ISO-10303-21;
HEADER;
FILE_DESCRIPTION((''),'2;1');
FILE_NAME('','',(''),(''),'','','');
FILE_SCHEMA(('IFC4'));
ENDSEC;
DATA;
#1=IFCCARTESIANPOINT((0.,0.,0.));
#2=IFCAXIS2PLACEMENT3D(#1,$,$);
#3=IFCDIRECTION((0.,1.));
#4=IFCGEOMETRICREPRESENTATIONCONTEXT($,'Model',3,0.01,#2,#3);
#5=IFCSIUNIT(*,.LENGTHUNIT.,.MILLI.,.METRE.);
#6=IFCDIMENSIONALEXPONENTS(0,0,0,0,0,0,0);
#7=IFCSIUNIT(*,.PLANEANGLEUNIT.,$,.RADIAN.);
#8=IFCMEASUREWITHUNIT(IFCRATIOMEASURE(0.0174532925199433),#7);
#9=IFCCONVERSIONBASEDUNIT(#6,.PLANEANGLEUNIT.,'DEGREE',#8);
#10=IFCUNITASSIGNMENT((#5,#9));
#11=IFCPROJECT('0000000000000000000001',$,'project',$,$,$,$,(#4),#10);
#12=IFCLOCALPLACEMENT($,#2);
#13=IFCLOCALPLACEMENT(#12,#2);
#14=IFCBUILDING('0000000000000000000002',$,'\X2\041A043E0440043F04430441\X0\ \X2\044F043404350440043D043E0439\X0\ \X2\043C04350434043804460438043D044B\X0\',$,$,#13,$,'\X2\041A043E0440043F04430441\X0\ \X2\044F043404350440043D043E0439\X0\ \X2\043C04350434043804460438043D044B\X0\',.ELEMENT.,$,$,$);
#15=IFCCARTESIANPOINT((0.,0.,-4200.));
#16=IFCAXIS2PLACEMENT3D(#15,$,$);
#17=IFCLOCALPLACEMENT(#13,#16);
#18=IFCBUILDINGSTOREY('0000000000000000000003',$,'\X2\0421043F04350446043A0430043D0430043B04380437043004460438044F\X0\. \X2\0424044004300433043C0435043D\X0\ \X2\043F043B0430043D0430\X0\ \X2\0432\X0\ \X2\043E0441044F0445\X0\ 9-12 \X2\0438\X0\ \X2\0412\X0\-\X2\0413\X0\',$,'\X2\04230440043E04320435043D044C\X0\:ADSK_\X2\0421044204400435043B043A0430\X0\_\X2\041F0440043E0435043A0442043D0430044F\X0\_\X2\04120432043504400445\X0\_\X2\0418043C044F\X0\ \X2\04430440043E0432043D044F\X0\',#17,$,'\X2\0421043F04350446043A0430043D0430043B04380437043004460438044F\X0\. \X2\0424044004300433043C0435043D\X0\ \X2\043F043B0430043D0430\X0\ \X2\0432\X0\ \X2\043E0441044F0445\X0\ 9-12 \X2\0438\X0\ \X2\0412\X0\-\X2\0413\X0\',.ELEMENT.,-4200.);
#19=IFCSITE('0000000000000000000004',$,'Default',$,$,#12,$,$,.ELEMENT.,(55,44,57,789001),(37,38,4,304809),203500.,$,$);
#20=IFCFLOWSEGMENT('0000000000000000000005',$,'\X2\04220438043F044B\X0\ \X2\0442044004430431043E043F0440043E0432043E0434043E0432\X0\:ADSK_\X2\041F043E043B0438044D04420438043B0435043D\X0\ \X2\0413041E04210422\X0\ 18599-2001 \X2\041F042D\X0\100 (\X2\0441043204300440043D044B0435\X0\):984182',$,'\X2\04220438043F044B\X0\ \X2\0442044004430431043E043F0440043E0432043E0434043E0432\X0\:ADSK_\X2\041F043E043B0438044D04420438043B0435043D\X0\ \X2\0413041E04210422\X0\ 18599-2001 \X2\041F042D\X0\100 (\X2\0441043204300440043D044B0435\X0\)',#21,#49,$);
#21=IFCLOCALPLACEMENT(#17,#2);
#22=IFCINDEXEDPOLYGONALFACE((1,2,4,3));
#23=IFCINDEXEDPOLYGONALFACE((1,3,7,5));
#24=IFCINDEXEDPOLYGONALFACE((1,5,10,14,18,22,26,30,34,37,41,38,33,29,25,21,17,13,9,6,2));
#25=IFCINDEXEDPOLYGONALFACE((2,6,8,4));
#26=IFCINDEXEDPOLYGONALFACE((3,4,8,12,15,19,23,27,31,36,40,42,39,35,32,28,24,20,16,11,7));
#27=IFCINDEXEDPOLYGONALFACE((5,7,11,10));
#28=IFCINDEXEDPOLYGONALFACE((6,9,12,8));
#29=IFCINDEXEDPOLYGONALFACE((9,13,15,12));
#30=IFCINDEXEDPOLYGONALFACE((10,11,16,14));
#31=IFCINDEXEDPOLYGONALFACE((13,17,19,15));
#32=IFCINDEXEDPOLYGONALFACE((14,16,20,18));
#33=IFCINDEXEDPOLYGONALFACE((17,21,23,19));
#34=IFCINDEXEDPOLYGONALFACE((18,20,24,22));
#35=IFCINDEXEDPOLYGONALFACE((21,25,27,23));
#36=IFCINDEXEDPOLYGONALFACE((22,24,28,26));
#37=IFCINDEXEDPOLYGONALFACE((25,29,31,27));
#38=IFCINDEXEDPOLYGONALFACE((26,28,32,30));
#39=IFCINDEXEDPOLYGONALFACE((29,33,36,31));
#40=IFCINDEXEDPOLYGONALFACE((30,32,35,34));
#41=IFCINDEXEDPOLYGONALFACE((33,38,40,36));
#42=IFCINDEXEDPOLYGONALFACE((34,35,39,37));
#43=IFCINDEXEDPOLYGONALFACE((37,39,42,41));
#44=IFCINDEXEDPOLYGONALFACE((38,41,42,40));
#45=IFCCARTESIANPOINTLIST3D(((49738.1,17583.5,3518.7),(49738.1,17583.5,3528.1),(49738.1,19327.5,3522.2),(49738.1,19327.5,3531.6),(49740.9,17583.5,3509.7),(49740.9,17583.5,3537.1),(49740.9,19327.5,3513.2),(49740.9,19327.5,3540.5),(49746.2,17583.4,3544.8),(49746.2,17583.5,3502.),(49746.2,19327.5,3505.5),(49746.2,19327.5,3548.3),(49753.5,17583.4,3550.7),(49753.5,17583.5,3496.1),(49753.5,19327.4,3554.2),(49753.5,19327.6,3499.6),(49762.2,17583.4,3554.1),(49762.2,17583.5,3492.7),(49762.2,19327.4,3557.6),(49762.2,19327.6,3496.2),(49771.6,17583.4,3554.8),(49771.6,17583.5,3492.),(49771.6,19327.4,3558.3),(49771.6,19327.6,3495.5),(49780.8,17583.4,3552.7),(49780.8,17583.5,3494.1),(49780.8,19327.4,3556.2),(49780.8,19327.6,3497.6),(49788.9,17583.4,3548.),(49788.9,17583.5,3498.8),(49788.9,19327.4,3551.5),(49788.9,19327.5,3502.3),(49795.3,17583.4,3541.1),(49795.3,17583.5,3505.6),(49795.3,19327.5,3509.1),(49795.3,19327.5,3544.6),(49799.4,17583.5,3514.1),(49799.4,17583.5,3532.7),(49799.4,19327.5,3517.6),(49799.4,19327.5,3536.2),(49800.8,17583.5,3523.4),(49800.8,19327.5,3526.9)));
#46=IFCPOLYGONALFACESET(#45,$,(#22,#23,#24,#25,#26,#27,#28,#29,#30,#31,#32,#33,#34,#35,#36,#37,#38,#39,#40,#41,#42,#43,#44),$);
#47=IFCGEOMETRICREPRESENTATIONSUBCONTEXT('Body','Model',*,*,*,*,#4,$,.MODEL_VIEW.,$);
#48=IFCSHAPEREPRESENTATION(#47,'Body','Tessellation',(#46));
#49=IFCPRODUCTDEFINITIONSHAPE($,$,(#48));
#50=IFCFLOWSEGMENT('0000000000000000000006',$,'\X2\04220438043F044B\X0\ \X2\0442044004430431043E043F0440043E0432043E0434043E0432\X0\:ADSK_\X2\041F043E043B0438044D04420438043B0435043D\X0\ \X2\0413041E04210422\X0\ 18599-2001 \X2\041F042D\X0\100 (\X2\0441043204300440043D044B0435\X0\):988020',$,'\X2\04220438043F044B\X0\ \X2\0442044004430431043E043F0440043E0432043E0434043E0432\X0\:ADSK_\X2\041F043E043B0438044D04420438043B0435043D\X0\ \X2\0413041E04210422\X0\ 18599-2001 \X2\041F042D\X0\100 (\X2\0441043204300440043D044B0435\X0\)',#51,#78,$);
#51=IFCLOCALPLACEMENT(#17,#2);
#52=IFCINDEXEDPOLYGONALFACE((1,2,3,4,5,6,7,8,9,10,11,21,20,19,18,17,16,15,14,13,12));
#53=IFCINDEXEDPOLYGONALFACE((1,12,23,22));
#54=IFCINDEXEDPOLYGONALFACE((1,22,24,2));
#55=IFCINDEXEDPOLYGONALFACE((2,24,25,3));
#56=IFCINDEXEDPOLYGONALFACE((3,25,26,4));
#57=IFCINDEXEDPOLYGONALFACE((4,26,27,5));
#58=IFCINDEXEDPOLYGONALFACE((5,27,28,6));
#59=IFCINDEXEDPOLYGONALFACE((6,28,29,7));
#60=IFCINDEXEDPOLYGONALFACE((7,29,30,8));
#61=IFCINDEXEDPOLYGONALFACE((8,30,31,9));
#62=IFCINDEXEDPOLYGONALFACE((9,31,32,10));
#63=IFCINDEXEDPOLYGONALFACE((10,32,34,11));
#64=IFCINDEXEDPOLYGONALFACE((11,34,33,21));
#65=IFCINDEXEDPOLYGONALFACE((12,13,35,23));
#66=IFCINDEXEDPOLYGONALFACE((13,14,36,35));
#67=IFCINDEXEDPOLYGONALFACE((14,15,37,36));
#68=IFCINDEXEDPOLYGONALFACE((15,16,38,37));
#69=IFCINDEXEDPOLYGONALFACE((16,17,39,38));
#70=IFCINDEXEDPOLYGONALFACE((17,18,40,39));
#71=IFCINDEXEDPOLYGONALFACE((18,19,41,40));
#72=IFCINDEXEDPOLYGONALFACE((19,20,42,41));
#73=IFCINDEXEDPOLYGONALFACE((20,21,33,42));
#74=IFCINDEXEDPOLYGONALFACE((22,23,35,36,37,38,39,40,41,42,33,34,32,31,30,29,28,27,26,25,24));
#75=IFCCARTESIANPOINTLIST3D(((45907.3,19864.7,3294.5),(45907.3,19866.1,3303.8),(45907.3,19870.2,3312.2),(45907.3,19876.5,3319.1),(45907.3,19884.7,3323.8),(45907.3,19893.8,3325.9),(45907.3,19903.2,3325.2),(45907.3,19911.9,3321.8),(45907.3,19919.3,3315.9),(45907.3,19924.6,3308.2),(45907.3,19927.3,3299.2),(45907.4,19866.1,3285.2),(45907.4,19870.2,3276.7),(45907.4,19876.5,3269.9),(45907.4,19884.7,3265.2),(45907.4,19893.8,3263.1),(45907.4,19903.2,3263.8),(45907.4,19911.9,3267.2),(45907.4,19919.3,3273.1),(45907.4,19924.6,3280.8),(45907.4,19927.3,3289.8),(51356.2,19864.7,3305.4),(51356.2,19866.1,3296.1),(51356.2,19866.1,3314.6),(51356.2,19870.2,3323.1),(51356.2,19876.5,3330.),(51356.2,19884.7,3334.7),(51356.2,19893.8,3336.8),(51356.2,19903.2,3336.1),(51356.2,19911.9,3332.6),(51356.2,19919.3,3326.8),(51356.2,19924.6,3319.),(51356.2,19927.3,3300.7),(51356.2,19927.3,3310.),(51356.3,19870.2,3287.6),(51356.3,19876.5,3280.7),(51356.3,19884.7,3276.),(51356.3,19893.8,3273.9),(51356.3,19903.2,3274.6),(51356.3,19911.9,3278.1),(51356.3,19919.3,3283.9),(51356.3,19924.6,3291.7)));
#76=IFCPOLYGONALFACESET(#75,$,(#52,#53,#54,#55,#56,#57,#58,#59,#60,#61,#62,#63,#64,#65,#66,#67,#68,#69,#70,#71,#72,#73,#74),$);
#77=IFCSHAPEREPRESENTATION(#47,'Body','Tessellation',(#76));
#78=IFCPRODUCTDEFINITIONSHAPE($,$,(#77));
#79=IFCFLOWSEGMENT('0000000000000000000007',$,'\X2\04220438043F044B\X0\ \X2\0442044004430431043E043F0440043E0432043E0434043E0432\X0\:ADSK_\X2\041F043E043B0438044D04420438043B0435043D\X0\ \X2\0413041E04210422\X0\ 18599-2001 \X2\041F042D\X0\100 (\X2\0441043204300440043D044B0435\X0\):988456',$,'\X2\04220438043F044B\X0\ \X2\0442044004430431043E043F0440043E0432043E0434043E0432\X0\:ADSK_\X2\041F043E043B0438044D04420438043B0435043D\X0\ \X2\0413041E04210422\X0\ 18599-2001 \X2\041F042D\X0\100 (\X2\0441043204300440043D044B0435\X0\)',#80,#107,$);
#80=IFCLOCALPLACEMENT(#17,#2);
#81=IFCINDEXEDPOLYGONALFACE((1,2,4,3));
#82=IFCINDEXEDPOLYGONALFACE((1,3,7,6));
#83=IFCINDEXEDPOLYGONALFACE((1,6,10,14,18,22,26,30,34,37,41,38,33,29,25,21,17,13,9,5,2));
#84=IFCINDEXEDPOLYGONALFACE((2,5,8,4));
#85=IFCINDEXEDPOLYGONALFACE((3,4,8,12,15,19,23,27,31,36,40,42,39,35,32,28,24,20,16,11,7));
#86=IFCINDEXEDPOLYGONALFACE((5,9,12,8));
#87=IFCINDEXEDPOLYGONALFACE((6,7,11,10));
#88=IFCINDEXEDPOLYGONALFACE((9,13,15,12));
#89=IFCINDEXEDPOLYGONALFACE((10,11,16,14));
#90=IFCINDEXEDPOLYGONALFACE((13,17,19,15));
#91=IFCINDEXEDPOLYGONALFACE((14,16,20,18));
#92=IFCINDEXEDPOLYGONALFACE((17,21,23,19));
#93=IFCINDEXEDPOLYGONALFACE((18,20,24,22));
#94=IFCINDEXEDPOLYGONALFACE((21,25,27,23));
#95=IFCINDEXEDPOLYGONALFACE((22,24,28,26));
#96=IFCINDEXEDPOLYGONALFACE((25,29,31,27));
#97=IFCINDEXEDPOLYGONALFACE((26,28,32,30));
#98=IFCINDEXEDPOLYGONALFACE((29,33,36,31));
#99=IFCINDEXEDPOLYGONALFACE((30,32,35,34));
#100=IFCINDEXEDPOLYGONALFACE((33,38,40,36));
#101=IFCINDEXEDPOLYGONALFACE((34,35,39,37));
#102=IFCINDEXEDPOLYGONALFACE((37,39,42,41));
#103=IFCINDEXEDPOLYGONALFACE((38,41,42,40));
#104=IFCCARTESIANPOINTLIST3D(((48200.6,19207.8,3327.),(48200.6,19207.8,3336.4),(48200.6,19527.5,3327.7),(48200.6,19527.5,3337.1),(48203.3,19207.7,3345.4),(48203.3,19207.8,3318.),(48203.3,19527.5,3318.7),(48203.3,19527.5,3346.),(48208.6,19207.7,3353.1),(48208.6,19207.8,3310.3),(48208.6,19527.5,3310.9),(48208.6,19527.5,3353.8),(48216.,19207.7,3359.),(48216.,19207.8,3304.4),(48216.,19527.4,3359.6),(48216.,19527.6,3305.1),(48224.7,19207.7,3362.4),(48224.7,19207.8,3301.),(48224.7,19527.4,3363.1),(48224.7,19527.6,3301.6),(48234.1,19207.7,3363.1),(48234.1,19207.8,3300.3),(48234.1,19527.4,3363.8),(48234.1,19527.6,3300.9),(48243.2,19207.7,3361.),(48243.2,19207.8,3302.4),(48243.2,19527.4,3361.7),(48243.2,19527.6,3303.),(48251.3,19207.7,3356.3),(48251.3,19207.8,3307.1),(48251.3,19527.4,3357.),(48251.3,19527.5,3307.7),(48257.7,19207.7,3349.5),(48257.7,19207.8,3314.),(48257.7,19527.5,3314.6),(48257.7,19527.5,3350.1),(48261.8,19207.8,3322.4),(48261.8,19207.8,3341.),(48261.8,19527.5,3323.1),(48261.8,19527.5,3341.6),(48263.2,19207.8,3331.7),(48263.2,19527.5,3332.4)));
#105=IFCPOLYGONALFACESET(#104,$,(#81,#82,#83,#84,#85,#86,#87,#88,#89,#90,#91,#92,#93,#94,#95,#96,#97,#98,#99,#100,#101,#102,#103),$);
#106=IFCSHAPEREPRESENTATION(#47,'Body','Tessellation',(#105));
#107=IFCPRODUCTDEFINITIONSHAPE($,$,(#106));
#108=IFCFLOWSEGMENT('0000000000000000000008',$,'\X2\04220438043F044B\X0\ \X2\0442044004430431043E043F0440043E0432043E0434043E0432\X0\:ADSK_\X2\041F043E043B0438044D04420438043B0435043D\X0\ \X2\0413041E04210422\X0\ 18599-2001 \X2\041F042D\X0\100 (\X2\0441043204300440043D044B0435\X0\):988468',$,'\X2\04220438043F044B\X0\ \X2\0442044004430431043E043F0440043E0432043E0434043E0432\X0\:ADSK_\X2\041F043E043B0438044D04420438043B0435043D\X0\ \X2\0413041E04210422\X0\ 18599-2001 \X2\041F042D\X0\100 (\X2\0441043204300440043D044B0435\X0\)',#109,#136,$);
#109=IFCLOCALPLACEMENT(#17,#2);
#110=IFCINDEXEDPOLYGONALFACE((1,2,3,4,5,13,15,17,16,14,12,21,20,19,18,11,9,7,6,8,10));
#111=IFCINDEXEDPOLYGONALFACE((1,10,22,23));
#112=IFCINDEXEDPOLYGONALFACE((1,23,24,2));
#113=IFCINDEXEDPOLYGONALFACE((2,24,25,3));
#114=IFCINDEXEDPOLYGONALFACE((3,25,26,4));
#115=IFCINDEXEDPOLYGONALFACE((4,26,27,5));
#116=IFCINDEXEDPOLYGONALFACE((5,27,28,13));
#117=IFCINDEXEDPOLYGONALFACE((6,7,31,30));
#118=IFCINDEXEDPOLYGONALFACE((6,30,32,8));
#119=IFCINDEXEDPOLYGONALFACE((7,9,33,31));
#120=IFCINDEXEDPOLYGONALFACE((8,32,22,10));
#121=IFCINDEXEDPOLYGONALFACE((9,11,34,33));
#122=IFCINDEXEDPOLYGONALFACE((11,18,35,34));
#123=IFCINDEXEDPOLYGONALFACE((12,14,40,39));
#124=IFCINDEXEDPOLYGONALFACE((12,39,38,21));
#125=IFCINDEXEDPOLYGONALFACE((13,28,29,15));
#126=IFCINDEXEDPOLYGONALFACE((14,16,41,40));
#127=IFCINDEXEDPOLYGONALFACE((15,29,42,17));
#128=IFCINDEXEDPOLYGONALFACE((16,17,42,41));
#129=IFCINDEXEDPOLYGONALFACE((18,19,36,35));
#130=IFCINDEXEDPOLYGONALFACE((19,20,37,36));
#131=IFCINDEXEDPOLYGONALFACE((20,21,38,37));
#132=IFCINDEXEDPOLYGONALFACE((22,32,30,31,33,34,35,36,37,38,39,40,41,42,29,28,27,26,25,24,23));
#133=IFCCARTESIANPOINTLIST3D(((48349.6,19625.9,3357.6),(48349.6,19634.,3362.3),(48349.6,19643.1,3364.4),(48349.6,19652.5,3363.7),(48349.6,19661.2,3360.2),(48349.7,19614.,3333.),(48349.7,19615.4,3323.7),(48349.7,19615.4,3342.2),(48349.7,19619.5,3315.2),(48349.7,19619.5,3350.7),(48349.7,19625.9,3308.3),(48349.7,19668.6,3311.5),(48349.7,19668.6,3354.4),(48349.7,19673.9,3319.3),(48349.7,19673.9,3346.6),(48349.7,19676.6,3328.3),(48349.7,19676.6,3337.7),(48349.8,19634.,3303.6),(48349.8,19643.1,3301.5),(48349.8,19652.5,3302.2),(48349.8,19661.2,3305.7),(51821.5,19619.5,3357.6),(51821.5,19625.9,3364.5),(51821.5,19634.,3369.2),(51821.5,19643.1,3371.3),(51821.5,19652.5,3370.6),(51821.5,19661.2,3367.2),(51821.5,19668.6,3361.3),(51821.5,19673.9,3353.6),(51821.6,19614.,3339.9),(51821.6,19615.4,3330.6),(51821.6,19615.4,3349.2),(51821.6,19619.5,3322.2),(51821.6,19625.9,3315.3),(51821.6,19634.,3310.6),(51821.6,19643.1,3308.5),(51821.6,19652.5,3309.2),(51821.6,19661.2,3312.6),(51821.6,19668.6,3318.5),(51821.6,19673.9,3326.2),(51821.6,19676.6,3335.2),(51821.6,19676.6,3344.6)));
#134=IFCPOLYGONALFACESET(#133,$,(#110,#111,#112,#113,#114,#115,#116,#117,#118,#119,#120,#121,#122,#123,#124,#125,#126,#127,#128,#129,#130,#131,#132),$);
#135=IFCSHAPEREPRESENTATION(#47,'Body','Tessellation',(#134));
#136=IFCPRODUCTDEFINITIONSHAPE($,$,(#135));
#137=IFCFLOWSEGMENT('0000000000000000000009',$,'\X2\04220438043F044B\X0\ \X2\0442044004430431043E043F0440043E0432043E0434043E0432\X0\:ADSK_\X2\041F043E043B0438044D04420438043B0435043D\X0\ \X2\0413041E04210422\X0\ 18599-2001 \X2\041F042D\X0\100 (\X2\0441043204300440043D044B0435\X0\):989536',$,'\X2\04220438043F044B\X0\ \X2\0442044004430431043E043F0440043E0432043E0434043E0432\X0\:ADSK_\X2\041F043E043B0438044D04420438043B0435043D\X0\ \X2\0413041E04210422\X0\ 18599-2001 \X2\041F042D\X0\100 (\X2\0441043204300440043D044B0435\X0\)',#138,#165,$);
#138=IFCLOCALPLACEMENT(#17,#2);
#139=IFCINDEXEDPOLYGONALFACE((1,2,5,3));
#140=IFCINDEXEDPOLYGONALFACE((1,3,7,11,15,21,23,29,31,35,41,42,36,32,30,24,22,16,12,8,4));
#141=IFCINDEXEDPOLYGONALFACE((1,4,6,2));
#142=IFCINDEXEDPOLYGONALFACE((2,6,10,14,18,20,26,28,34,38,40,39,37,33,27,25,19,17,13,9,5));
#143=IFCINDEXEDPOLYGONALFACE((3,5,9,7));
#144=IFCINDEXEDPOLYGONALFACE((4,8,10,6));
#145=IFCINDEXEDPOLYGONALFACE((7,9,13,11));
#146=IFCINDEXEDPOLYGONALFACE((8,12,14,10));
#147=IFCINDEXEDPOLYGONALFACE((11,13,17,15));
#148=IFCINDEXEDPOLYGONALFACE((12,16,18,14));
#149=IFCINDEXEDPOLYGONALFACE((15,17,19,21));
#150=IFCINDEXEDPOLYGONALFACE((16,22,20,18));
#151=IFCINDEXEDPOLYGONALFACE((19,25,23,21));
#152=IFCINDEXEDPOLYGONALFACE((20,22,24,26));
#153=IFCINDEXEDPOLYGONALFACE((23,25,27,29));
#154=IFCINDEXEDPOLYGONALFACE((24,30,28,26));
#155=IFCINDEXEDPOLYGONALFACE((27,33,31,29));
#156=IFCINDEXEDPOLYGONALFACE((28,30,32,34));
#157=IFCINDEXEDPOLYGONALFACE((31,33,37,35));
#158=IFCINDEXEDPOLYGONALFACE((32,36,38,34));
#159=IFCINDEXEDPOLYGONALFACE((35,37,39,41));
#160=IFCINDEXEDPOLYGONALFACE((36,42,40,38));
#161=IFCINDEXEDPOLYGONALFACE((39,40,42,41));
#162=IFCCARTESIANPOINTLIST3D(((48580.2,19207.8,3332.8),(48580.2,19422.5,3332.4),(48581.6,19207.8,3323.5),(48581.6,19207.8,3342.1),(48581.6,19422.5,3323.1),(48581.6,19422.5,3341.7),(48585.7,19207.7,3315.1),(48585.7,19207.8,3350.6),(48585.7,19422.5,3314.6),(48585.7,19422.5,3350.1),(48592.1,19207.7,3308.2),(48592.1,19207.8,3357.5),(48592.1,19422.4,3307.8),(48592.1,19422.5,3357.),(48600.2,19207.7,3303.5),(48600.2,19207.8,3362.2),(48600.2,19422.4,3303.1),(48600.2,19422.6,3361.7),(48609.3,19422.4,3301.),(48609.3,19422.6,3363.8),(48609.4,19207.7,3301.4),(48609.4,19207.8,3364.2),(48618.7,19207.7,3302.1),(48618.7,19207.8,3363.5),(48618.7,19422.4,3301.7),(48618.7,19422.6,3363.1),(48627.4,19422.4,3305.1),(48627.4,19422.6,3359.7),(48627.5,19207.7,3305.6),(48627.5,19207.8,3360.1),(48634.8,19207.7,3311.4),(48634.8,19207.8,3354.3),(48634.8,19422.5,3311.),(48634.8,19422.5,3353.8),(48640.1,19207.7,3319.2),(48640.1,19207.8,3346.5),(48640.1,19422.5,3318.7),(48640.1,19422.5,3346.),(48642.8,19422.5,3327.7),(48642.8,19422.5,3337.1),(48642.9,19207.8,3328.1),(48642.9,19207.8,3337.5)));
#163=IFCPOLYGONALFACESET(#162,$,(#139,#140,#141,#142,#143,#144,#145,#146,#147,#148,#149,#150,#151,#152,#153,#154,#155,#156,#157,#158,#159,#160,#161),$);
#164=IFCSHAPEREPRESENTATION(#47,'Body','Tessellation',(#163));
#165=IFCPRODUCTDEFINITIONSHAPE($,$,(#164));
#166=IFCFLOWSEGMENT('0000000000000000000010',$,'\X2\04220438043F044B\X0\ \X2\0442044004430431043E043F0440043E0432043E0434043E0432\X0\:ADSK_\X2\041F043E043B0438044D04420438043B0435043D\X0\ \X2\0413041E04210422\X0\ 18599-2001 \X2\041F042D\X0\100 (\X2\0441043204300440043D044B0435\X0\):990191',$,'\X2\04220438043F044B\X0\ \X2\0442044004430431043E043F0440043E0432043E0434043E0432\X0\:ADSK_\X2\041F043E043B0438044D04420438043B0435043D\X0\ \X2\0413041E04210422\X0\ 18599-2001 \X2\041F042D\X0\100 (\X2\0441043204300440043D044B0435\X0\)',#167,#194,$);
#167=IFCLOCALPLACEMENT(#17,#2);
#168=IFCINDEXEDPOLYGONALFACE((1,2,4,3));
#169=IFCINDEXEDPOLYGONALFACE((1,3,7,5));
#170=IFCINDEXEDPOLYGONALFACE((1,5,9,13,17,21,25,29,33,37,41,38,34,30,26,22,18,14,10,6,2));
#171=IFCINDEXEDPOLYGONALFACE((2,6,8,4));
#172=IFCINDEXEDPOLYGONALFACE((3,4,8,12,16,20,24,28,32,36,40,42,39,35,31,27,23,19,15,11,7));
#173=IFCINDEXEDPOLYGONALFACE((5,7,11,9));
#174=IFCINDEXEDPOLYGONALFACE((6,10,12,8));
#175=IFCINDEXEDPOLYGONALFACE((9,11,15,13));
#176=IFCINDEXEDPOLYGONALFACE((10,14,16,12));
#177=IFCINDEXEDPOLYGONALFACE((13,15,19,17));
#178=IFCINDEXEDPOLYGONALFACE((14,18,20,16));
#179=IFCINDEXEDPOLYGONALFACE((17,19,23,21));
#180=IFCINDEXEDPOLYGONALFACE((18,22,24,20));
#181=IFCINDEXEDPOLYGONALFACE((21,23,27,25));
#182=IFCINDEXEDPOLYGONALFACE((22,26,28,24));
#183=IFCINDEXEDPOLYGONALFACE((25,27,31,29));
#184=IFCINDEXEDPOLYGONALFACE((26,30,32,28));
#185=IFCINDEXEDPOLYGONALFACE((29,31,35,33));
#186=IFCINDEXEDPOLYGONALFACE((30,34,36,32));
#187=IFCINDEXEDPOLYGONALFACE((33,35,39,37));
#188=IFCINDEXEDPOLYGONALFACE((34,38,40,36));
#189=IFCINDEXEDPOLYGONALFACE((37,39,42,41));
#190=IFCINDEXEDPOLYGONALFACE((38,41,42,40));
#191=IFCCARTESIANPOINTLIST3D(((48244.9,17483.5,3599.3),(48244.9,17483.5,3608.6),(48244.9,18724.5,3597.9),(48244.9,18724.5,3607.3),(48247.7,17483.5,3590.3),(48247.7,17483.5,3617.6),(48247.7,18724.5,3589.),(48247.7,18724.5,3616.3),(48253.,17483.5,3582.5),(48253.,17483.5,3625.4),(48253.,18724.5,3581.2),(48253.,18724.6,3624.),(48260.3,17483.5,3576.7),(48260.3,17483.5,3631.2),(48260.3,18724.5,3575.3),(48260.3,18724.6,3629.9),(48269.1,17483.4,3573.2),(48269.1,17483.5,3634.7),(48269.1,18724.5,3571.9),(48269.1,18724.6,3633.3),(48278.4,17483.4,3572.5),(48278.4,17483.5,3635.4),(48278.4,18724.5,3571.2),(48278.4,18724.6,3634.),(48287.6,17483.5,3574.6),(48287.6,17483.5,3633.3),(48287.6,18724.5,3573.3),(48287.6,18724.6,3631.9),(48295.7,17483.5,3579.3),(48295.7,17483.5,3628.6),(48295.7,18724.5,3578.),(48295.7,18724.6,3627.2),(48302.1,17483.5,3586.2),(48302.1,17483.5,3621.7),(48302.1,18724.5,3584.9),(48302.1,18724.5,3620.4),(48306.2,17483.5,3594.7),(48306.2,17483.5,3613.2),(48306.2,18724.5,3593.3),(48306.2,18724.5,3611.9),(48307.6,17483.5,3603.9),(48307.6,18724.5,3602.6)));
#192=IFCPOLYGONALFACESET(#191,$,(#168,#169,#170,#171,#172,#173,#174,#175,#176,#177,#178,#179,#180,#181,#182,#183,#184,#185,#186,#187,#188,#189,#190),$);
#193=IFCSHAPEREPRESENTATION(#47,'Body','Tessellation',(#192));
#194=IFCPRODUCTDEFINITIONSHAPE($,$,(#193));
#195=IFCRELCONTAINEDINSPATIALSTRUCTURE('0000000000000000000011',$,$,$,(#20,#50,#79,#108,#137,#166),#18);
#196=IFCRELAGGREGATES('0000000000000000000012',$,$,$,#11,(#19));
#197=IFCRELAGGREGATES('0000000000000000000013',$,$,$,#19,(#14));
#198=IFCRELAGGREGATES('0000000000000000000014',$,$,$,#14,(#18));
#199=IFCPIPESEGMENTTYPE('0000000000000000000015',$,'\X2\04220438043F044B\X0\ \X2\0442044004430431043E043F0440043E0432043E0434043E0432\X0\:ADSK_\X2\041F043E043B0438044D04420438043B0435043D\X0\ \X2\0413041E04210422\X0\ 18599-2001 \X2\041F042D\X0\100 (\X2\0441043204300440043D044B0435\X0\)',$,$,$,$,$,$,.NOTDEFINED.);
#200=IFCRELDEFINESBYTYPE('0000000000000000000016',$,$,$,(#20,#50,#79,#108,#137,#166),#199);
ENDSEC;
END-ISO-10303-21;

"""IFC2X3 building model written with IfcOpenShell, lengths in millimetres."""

from ifc_helpers import new_model, entity, si_unit, converted_unit, direction, frame, frame_2d, origin, origin_2d_with_axis, place, context, subcontext, project, spatial, circle, extrude, type_object, element, save


model = new_model("IFC2X3")

# Units and contexts
model_context = context("Model", 3, precision=0.01, world=origin(), true_north=direction((0.0, 1.0)))
body_context = subcontext(model_context, "Body", "Model", "MODEL_VIEW")
ifc_project = project(units=[si_unit("LENGTHUNIT", "METRE", prefix="MILLI"), converted_unit("PLANEANGLEUNIT", "DEGREE", entity("IfcRatioMeasure", 0.0174532925199433), si_unit("PLANEANGLEUNIT", "RADIAN"), dimensions=[0, 0, 0, 0, 0, 0, 0])], contexts=[model_context])

# Site, building, storey
site_placement = place(None, frame((0.0, 0.0, 0.0)))
site = spatial("IfcSite", under=ifc_project, at=site_placement, Name="Default", CompositionType="ELEMENT", RefLatitude=(55, 44, 57, 789001), RefLongitude=(37, 38, 4, 304809), RefElevation=203500.0)
building_placement = place(site_placement, origin())
building = spatial("IfcBuilding", under=site, at=building_placement, Name="Корпус ядерной медицины", LongName="Корпус ядерной медицины", CompositionType="ELEMENT")
storey_placement = place(building_placement, frame((0.0, 0.0, -4200.0)))
storey = spatial("IfcBuildingStorey", under=building, at=storey_placement, Name="Спецканализация. Фрагмен плана в осях 9-12 и В-Г", ObjectType="Уровень:ADSK_Стрелка_Проектная_Вверх_Имя уровня", LongName="Спецканализация. Фрагмен плана в осях 9-12 и В-Г", CompositionType="ELEMENT", Elevation=-4200.0)

# Flow segments
pipe_segment_type = type_object("IfcPipeSegmentType", Name="Типы трубопроводов:ADSK_Полиэтилен ГОСТ 18599-2001 ПЭ100 (сварные)", PredefinedType="NOTDEFINED")
flow_segment_1_placement = place(storey_placement, frame((49736.2, 17583.4, 3490.3)))
element("IfcFlowSegment", 1, at=flow_segment_1_placement, inside=storey, type_object=pipe_segment_type, Name="Типы трубопроводов:ADSK_Полиэтилен ГОСТ 18599-2001 ПЭ100 (сварные):984182", ObjectType="Типы трубопроводов:ADSK_Полиэтилен ГОСТ 18599-2001 ПЭ100 (сварные)", context=body_context, shape_type="SweptSolid", body=[
    extrude(circle(Radius=31.5, at=origin_2d_with_axis()), frame((33.1, 0.1, 33.1), z_axis=(0.0, 0.999998, 0.002), x_axis=(1.0, 0.0, 0.0)), (0.0, 0.0, 1.0), 1744.0),
])
flow_segment_2_placement = place(storey_placement, frame((45907.3, 19863.1, 3261.4)))
element("IfcFlowSegment", 2, at=flow_segment_2_placement, inside=storey, type_object=pipe_segment_type, Name="Типы трубопроводов:ADSK_Полиэтилен ГОСТ 18599-2001 ПЭ100 (сварные):988020", ObjectType="Типы трубопроводов:ADSK_Полиэтилен ГОСТ 18599-2001 ПЭ100 (сварные)", context=body_context, shape_type="SweptSolid", body=[
    extrude(circle(Radius=31.5, at=origin_2d_with_axis()), frame((0.1, 33.1, 33.1), z_axis=(0.999998, 0.0, 0.001995), x_axis=(0.0, -1.0, 0.0)), (0.0, 0.0, 1.0), 5448.9),
])
flow_segment_3_placement = place(storey_placement, frame((48198.6, 19207.7, 3298.6)))
element("IfcFlowSegment", 3, at=flow_segment_3_placement, inside=storey, type_object=pipe_segment_type, Name="Типы трубопроводов:ADSK_Полиэтилен ГОСТ 18599-2001 ПЭ100 (сварные):988456", ObjectType="Типы трубопроводов:ADSK_Полиэтилен ГОСТ 18599-2001 ПЭ100 (сварные)", context=body_context, shape_type="SweptSolid", body=[
    extrude(circle(Radius=31.5, at=origin_2d_with_axis()), frame((33.1, 0.1, 33.1), z_axis=(-0.000006, 0.999998, 0.002035), x_axis=(1.0, 0.000006, 0.0)), (0.0, 0.0, 1.0), 319.7),
])
flow_segment_4_placement = place(storey_placement, frame((48349.6, 19612.4, 3299.9)))
element("IfcFlowSegment", 4, at=flow_segment_4_placement, inside=storey, type_object=pipe_segment_type, Name="Типы трубопроводов:ADSK_Полиэтилен ГОСТ 18599-2001 ПЭ100 (сварные):988468", ObjectType="Типы трубопроводов:ADSK_Полиэтилен ГОСТ 18599-2001 ПЭ100 (сварные)", context=body_context, shape_type="SweptSolid", body=[
    extrude(circle(Radius=31.5, at=frame_2d((0.0, 0.0), x_axis=(1.0, 0.0))), frame((0.1, 33.1, 33.1), z_axis=(0.999998, 0.0, 0.002), x_axis=(0.0, -1.0, 0.0)), (0.0, 0.0, 1.0), 3471.9),
])
flow_segment_5_placement = place(storey_placement, frame((48578.6, 19207.7, 3299.3)))
element("IfcFlowSegment", 5, at=flow_segment_5_placement, inside=storey, type_object=pipe_segment_type, Name="Типы трубопроводов:ADSK_Полиэтилен ГОСТ 18599-2001 ПЭ100 (сварные):989536", ObjectType="Типы трубопроводов:ADSK_Полиэтилен ГОСТ 18599-2001 ПЭ100 (сварные)", context=body_context, shape_type="SweptSolid", body=[
    extrude(circle(Radius=31.5, at=origin_2d_with_axis()), frame((33.1, 0.1, 33.5), z_axis=(-0.000038, 0.999998, -0.002099), x_axis=(-1.0, -0.000038, 0.0)), (0.0, 0.0, 1.0), 214.7),
])
flow_segment_6_placement = place(storey_placement, frame((48243.0, 17483.4, 3569.5)))
element("IfcFlowSegment", 6, at=flow_segment_6_placement, inside=storey, type_object=pipe_segment_type, Name="Типы трубопроводов:ADSK_Полиэтилен ГОСТ 18599-2001 ПЭ100 (сварные):990191", ObjectType="Типы трубопроводов:ADSK_Полиэтилен ГОСТ 18599-2001 ПЭ100 (сварные)", context=body_context, shape_type="SweptSolid", body=[
    extrude(circle(Radius=31.5, at=frame_2d((0.0, 0.0), x_axis=(1.0, 0.0))), frame((33.1, 1241.1, 33.1), z_axis=(0.0, -0.999999, 0.00107), x_axis=(1.0, 0.0, 0.0)), (0.0, 0.0, 1.0), 1241.0),
])

save(model, "model.ifc")
